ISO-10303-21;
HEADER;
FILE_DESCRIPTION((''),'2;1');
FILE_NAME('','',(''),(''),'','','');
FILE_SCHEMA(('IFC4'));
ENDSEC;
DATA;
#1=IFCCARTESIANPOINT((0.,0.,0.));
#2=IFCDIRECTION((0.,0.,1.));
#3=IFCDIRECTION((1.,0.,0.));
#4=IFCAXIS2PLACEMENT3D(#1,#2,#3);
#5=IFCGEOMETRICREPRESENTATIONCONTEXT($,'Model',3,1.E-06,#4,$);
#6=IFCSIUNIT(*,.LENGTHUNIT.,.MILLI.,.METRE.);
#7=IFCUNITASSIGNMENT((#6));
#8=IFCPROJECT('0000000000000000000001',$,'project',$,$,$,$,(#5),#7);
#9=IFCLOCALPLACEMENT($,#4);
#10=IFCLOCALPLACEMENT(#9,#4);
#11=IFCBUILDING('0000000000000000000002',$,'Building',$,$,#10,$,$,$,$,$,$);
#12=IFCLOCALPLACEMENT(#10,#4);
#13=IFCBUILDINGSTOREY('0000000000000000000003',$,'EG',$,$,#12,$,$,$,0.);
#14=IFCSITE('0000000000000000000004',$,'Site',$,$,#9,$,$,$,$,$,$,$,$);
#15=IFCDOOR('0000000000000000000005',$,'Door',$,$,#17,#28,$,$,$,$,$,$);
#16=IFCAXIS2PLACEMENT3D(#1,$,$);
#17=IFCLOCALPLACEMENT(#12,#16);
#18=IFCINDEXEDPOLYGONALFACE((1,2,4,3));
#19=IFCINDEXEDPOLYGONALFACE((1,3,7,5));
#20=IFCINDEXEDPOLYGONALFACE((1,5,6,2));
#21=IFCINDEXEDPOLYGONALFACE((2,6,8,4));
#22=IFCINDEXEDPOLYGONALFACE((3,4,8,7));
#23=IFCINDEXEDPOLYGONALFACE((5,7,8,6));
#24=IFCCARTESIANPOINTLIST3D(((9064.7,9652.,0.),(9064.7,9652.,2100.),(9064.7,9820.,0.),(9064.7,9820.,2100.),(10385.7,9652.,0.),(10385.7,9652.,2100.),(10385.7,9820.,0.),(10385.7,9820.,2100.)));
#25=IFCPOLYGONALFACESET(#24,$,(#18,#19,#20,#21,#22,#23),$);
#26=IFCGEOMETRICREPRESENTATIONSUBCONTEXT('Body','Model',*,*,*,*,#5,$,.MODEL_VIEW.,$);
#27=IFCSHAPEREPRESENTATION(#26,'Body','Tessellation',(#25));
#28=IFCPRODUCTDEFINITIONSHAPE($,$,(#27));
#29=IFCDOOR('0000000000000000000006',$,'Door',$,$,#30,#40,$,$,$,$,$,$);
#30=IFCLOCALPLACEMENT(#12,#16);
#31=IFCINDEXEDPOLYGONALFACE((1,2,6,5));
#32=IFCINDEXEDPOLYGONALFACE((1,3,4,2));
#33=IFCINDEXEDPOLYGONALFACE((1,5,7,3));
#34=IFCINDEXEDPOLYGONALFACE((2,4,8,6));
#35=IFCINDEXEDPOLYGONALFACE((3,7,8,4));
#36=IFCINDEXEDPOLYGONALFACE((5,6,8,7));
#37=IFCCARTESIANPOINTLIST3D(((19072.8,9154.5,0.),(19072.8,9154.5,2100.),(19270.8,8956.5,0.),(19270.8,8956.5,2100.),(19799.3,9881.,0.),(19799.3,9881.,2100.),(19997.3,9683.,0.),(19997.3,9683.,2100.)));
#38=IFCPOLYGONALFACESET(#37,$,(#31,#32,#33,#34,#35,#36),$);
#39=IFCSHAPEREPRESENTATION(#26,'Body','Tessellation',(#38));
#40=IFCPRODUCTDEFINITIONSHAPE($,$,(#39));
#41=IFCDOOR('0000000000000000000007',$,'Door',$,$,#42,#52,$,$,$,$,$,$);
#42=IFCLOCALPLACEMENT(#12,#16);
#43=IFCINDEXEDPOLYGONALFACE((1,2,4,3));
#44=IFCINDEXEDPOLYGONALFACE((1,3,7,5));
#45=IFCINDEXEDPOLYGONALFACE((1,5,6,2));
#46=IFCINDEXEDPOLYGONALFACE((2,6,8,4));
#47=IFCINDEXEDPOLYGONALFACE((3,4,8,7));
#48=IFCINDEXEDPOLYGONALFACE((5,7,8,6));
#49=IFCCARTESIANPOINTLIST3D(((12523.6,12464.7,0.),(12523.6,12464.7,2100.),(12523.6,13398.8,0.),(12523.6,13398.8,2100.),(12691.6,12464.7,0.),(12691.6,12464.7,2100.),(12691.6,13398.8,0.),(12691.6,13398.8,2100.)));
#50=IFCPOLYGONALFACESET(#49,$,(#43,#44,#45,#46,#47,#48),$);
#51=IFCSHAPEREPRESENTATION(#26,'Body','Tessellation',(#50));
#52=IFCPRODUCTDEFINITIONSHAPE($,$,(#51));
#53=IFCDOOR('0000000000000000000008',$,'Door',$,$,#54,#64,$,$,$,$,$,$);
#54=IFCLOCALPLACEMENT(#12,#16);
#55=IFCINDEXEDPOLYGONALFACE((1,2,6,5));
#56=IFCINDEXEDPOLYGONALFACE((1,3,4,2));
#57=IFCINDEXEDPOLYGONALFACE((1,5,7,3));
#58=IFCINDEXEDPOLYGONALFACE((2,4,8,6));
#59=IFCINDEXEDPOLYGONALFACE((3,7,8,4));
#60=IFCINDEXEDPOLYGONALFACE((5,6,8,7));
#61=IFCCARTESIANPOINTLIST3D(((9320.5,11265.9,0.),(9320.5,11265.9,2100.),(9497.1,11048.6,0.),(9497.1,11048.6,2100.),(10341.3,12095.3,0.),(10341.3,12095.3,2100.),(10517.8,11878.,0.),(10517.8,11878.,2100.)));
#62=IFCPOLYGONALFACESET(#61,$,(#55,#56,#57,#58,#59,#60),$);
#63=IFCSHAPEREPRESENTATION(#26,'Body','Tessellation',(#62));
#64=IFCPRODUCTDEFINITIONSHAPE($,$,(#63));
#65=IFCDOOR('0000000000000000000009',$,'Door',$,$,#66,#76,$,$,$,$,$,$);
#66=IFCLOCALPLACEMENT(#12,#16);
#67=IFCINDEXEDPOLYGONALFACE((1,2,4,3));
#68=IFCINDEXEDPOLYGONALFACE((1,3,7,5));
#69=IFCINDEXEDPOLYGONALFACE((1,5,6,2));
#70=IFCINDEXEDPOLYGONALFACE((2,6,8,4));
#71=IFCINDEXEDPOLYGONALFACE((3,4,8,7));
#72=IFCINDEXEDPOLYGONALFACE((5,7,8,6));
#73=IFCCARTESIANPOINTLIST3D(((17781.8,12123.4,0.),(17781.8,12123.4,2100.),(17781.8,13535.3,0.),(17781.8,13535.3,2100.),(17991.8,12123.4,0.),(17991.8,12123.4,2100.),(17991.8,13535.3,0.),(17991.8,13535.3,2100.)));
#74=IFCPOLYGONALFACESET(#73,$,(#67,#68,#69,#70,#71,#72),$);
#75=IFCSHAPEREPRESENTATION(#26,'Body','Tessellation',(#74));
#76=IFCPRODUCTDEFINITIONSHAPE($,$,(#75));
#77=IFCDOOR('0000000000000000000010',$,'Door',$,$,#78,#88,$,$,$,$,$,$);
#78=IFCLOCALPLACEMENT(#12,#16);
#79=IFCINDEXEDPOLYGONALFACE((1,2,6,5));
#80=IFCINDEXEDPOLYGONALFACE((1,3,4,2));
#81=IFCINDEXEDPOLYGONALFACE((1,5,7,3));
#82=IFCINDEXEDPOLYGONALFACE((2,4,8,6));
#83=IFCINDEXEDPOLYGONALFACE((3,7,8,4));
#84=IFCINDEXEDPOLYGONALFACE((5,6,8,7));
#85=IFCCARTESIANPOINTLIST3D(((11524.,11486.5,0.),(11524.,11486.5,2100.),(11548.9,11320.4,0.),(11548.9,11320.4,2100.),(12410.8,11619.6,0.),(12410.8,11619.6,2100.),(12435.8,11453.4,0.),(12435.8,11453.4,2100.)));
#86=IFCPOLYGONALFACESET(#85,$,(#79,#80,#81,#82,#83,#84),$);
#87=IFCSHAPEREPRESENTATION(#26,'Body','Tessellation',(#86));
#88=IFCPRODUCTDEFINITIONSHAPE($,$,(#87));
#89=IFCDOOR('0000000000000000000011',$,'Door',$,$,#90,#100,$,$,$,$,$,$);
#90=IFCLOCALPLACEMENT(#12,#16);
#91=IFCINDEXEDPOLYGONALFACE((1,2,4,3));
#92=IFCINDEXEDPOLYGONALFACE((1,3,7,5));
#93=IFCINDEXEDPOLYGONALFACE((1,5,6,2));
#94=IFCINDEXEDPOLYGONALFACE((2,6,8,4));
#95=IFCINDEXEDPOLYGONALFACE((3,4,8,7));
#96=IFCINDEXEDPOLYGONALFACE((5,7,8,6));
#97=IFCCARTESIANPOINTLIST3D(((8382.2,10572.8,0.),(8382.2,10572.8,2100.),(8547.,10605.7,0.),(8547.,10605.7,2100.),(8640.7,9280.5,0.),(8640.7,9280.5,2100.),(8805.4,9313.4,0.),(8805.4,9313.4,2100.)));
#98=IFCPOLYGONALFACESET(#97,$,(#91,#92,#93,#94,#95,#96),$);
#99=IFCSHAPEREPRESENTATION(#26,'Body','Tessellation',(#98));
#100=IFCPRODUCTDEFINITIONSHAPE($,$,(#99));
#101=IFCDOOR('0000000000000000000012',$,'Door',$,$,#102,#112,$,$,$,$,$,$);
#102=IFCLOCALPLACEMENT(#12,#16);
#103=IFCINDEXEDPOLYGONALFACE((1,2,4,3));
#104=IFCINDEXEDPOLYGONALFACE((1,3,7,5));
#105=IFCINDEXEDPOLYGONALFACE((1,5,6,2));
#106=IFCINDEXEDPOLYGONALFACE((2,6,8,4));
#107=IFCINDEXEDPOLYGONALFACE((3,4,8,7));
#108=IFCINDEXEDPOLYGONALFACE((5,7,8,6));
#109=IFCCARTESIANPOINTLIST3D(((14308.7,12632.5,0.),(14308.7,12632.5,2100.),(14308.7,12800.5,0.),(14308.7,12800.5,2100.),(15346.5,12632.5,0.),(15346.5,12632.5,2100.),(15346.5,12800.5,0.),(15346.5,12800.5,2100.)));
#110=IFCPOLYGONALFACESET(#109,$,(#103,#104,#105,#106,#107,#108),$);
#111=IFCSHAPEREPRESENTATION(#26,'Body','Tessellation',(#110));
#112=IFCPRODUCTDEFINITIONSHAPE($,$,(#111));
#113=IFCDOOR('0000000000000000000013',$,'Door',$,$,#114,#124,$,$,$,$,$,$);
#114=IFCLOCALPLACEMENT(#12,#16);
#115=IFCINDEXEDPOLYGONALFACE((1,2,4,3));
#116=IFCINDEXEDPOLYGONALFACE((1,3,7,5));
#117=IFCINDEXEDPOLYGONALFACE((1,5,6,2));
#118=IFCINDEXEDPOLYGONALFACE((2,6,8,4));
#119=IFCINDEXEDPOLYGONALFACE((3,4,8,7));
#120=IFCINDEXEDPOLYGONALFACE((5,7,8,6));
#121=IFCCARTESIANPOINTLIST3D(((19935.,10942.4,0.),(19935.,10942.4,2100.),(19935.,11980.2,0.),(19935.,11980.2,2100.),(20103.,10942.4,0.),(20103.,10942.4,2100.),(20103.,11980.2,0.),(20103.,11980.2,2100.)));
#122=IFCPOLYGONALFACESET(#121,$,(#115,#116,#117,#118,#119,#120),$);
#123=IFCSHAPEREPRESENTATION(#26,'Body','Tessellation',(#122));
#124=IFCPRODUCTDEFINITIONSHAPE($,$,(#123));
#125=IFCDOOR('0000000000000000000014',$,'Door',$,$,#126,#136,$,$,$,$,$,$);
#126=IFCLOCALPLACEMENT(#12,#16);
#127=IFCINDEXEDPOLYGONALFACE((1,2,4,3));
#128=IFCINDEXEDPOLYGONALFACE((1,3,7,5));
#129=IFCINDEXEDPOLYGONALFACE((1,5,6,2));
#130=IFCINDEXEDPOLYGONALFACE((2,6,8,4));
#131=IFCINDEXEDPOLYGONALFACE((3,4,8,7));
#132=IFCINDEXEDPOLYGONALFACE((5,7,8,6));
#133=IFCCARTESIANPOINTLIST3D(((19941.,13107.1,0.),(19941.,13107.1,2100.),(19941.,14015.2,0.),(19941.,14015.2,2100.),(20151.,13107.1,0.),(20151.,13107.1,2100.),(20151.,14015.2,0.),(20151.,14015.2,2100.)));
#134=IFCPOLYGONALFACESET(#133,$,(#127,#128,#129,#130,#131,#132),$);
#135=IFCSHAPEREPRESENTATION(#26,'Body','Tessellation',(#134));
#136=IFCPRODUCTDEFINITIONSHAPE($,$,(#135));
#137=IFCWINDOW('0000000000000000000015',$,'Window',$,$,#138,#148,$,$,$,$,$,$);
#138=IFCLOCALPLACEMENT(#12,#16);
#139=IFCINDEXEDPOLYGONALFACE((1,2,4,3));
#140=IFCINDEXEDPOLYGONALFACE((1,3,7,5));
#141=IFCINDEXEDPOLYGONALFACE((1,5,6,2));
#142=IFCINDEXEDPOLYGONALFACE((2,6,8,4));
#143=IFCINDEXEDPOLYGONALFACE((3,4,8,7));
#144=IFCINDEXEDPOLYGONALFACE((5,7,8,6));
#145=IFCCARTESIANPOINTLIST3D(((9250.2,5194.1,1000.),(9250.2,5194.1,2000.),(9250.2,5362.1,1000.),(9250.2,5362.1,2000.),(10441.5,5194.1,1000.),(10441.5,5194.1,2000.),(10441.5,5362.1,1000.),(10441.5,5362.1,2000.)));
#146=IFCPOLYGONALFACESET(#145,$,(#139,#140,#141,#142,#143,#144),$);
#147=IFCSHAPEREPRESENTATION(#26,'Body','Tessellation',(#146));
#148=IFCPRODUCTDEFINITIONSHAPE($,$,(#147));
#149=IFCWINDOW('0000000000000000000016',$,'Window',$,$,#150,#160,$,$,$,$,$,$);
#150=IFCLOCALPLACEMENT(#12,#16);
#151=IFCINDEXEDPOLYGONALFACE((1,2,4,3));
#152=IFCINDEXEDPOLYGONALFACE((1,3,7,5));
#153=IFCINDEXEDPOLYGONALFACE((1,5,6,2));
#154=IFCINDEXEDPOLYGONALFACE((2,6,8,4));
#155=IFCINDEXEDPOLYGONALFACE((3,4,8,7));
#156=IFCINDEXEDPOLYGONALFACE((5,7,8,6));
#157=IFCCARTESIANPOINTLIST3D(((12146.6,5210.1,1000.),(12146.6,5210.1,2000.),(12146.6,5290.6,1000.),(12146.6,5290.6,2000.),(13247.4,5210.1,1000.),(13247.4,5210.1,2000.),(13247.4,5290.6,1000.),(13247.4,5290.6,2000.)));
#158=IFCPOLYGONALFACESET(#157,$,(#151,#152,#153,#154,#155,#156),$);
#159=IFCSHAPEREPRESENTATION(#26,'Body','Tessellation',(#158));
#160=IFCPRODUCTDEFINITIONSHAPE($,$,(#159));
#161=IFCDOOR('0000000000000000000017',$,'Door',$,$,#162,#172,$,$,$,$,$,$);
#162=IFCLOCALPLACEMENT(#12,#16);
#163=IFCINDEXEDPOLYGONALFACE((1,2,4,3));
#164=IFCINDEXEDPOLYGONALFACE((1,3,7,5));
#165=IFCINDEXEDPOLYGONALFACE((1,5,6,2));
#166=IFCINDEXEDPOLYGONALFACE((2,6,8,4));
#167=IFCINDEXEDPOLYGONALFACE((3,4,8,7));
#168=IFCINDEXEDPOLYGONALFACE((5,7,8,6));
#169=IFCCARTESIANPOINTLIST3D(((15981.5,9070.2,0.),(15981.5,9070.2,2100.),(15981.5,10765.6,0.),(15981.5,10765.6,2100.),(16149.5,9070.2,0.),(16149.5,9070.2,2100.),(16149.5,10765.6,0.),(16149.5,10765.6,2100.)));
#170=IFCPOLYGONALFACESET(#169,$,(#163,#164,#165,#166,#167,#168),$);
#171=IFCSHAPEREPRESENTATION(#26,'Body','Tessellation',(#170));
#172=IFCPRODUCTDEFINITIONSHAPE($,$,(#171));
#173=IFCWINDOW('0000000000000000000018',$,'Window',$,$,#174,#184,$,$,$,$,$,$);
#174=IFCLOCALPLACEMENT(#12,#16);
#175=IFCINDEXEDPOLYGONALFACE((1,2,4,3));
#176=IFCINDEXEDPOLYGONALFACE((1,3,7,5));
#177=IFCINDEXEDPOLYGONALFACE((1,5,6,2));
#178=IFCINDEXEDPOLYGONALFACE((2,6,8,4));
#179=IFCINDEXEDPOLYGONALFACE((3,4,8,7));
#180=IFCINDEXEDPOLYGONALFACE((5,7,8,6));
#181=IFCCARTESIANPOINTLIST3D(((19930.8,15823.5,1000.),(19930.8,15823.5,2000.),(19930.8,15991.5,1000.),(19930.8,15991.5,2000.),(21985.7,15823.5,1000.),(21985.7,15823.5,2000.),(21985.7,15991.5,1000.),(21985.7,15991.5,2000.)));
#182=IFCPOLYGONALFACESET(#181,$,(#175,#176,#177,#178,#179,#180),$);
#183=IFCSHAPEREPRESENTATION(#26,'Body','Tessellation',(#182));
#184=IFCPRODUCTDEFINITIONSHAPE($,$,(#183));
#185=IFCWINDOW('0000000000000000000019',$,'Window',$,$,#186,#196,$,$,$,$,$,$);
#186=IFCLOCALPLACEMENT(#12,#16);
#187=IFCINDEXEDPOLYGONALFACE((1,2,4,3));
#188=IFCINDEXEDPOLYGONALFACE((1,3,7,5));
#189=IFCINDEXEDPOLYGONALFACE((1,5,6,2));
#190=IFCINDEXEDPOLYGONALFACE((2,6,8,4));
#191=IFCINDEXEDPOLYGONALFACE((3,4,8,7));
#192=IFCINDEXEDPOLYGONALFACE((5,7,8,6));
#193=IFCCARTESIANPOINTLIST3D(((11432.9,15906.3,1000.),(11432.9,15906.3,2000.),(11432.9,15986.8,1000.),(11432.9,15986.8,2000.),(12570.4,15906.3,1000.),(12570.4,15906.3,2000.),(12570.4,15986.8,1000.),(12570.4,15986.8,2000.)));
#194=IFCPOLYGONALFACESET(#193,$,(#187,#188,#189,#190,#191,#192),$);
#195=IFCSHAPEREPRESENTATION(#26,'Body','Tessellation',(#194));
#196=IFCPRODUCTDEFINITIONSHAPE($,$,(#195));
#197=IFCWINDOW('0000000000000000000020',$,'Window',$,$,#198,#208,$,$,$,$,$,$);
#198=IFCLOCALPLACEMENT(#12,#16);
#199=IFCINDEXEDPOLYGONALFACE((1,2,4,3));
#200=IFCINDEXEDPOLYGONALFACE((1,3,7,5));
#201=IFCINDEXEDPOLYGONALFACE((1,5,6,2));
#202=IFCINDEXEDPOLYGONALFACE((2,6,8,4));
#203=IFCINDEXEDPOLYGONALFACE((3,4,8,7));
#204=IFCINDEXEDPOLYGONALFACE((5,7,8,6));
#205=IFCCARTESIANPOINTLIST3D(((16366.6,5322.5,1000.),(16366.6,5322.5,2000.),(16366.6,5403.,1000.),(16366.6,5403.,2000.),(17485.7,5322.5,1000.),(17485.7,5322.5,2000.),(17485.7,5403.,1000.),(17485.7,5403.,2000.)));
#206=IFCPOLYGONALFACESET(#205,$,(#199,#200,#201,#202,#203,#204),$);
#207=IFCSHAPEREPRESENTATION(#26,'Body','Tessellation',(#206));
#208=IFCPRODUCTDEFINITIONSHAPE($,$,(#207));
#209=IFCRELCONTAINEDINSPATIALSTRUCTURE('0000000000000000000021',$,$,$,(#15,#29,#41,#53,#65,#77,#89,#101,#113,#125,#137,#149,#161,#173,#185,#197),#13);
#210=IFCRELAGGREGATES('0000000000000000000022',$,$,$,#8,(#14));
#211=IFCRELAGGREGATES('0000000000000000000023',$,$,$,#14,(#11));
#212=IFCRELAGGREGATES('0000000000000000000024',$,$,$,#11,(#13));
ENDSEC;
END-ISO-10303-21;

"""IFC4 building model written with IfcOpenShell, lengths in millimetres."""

from ifc_helpers import new_model, si_unit, frame, origin_with_axes, place, context, subcontext, project, spatial, rectangle, extrude, element, save


model = new_model("IFC4")

# Units and contexts
model_context = context("Model", 3, precision=1e-06, world=origin_with_axes())
body_context = subcontext(model_context, "Body", "Model", "MODEL_VIEW")
ifc_project = project(units=[si_unit("LENGTHUNIT", "METRE", prefix="MILLI")], contexts=[model_context])

# Site, building, storey
site_placement = place(None, origin_with_axes())
site = spatial("IfcSite", under=ifc_project, at=site_placement, Name="Site")
building_placement = place(site_placement, origin_with_axes())
building = spatial("IfcBuilding", under=site, at=building_placement, Name="Building")
storey_placement = place(building_placement, origin_with_axes())
storey = spatial("IfcBuildingStorey", under=building, at=storey_placement, Name="EG", Elevation=0.0)

# Doors
door_1_placement = place(storey_placement, origin_with_axes())
element("IfcDoor", 1, at=door_1_placement, inside=storey, Name="Door", context=body_context, shape_type="SweptSolid", body=[
    extrude(rectangle(XDim=1321.0, YDim=168.0), frame((9725.2, 9736.0, 0.0), z_axis=(0.0, 0.0, 1.0), x_axis=(1.0, 0.0, 0.0)), (0.0, 0.0, 1.0), 2100.0),
])
door_2_placement = place(storey_placement, origin_with_axes())
element("IfcDoor", 2, at=door_2_placement, inside=storey, Name="Door", context=body_context, shape_type="SweptSolid", body=[
    extrude(rectangle(XDim=1027.4, YDim=280.0), frame((19535.1, 9418.8, 0.0), z_axis=(0.0, 0.0, 1.0), x_axis=(-0.707107, -0.707107, 0.0)), (0.0, 0.0, 1.0), 2100.0),
])
door_3_placement = place(storey_placement, origin_with_axes())
element("IfcDoor", 3, at=door_3_placement, inside=storey, Name="Door", context=body_context, shape_type="SweptSolid", body=[
    extrude(rectangle(XDim=934.1, YDim=168.0), frame((12607.6, 12931.8, 0.0), z_axis=(0.0, 0.0, 1.0), x_axis=(0.0, -1.0, 0.0)), (0.0, 0.0, 1.0), 2100.0),
])
door_4_placement = place(storey_placement, origin_with_axes())
element("IfcDoor", 4, at=door_4_placement, inside=storey, Name="Door", context=body_context, shape_type="SweptSolid", body=[
    extrude(rectangle(XDim=1315.2, YDim=280.0), frame((9919.2, 11572.0, 0.0), z_axis=(0.0, 0.0, 1.0), x_axis=(-0.776114, -0.630593, 0.0)), (0.0, 0.0, 1.0), 2100.0),
])
door_5_placement = place(storey_placement, origin_with_axes())
element("IfcDoor", 5, at=door_5_placement, inside=storey, Name="Door", context=body_context, shape_type="SweptSolid", body=[
    extrude(rectangle(XDim=1411.9, YDim=210.0), frame((17886.8, 12829.3, 0.0), z_axis=(0.0, 0.0, 1.0), x_axis=(0.0, 1.0, 0.0)), (0.0, 0.0, 1.0), 2100.0),
])
door_6_placement = place(storey_placement, origin_with_axes())
element("IfcDoor", 6, at=door_6_placement, inside=storey, Name="Door", context=body_context, shape_type="SweptSolid", body=[
    extrude(rectangle(XDim=896.8, YDim=168.0), frame((11979.9, 11470.0, 0.0), z_axis=(0.0, 0.0, 1.0), x_axis=(-0.988936, -0.14834, 0.0)), (0.0, 0.0, 1.0), 2100.0),
])
door_7_placement = place(storey_placement, origin_with_axes())
element("IfcDoor", 7, at=door_7_placement, inside=storey, Name="Door", context=body_context, shape_type="SweptSolid", body=[
    extrude(rectangle(XDim=1317.9, YDim=168.0), frame((8593.8, 9943.1, 0.0), z_axis=(0.0, 0.0, 1.0), x_axis=(-0.196116, 0.980581, 0.0)), (0.0, 0.0, 1.0), 2100.0),
])
door_8_placement = place(storey_placement, origin_with_axes())
element("IfcDoor", 8, at=door_8_placement, inside=storey, Name="Door", context=body_context, shape_type="SweptSolid", body=[
    extrude(rectangle(XDim=1037.8, YDim=168.0), frame((14827.6, 12716.5, 0.0), z_axis=(0.0, 0.0, 1.0), x_axis=(1.0, 0.0, 0.0)), (0.0, 0.0, 1.0), 2100.0),
])
door_9_placement = place(storey_placement, origin_with_axes())
element("IfcDoor", 9, at=door_9_placement, inside=storey, Name="Door", context=body_context, shape_type="SweptSolid", body=[
    extrude(rectangle(XDim=1037.8, YDim=168.0), frame((20019.0, 11461.3, 0.0), z_axis=(0.0, 0.0, 1.0), x_axis=(0.0, -1.0, 0.0)), (0.0, 0.0, 1.0), 2100.0),
])
door_10_placement = place(storey_placement, origin_with_axes())
element("IfcDoor", 10, at=door_10_placement, inside=storey, Name="Door", context=body_context, shape_type="SweptSolid", body=[
    extrude(rectangle(XDim=908.1, YDim=210.0), frame((20046.0, 13561.1, 0.0), z_axis=(0.0, 0.0, 1.0), x_axis=(0.0, -1.0, 0.0)), (0.0, 0.0, 1.0), 2100.0),
])

# Windows
window_1_placement = place(storey_placement, origin_with_axes())
element("IfcWindow", 11, at=window_1_placement, inside=storey, Name="Window", context=body_context, shape_type="SweptSolid", body=[
    extrude(rectangle(XDim=1191.3, YDim=168.0), frame((9845.8, 5278.1, 1000.0), z_axis=(0.0, 0.0, 1.0), x_axis=(1.0, 0.0, 0.0)), (0.0, 0.0, 1.0), 1000.0),
])
window_2_placement = place(storey_placement, origin_with_axes())
element("IfcWindow", 12, at=window_2_placement, inside=storey, Name="Window", context=body_context, shape_type="SweptSolid", body=[
    extrude(rectangle(XDim=1100.8, YDim=80.5), frame((12697.0, 5250.3, 1000.0), z_axis=(0.0, 0.0, 1.0), x_axis=(1.0, 0.0, 0.0)), (0.0, 0.0, 1.0), 1000.0),
])

# Door
door_11_placement = place(storey_placement, origin_with_axes())
element("IfcDoor", 13, at=door_11_placement, inside=storey, Name="Door", context=body_context, shape_type="SweptSolid", body=[
    extrude(rectangle(XDim=1695.3, YDim=168.0), frame((16065.5, 9917.9, 0.0), z_axis=(0.0, 0.0, 1.0), x_axis=(0.0, 1.0, 0.0)), (0.0, 0.0, 1.0), 2100.0),
])

# Windows
window_3_placement = place(storey_placement, origin_with_axes())
element("IfcWindow", 14, at=window_3_placement, inside=storey, Name="Window", context=body_context, shape_type="SweptSolid", body=[
    extrude(rectangle(XDim=2054.8, YDim=168.0), frame((20958.2, 15907.5, 1000.0), z_axis=(0.0, 0.0, 1.0), x_axis=(1.0, 0.0, 0.0)), (0.0, 0.0, 1.0), 1000.0),
])
window_4_placement = place(storey_placement, origin_with_axes())
element("IfcWindow", 15, at=window_4_placement, inside=storey, Name="Window", context=body_context, shape_type="SweptSolid", body=[
    extrude(rectangle(XDim=1137.5, YDim=80.5), frame((12001.7, 15946.5, 1000.0), z_axis=(0.0, 0.0, 1.0), x_axis=(1.0, 0.0, 0.0)), (0.0, 0.0, 1.0), 1000.0),
])
window_5_placement = place(storey_placement, origin_with_axes())
element("IfcWindow", 16, at=window_5_placement, inside=storey, Name="Window", context=body_context, shape_type="SweptSolid", body=[
    extrude(rectangle(XDim=1119.1, YDim=80.5), frame((16926.1, 5362.8, 1000.0), z_axis=(0.0, 0.0, 1.0), x_axis=(1.0, 0.0, 0.0)), (0.0, 0.0, 1.0), 1000.0),
])

save(model, "model.ifc")
